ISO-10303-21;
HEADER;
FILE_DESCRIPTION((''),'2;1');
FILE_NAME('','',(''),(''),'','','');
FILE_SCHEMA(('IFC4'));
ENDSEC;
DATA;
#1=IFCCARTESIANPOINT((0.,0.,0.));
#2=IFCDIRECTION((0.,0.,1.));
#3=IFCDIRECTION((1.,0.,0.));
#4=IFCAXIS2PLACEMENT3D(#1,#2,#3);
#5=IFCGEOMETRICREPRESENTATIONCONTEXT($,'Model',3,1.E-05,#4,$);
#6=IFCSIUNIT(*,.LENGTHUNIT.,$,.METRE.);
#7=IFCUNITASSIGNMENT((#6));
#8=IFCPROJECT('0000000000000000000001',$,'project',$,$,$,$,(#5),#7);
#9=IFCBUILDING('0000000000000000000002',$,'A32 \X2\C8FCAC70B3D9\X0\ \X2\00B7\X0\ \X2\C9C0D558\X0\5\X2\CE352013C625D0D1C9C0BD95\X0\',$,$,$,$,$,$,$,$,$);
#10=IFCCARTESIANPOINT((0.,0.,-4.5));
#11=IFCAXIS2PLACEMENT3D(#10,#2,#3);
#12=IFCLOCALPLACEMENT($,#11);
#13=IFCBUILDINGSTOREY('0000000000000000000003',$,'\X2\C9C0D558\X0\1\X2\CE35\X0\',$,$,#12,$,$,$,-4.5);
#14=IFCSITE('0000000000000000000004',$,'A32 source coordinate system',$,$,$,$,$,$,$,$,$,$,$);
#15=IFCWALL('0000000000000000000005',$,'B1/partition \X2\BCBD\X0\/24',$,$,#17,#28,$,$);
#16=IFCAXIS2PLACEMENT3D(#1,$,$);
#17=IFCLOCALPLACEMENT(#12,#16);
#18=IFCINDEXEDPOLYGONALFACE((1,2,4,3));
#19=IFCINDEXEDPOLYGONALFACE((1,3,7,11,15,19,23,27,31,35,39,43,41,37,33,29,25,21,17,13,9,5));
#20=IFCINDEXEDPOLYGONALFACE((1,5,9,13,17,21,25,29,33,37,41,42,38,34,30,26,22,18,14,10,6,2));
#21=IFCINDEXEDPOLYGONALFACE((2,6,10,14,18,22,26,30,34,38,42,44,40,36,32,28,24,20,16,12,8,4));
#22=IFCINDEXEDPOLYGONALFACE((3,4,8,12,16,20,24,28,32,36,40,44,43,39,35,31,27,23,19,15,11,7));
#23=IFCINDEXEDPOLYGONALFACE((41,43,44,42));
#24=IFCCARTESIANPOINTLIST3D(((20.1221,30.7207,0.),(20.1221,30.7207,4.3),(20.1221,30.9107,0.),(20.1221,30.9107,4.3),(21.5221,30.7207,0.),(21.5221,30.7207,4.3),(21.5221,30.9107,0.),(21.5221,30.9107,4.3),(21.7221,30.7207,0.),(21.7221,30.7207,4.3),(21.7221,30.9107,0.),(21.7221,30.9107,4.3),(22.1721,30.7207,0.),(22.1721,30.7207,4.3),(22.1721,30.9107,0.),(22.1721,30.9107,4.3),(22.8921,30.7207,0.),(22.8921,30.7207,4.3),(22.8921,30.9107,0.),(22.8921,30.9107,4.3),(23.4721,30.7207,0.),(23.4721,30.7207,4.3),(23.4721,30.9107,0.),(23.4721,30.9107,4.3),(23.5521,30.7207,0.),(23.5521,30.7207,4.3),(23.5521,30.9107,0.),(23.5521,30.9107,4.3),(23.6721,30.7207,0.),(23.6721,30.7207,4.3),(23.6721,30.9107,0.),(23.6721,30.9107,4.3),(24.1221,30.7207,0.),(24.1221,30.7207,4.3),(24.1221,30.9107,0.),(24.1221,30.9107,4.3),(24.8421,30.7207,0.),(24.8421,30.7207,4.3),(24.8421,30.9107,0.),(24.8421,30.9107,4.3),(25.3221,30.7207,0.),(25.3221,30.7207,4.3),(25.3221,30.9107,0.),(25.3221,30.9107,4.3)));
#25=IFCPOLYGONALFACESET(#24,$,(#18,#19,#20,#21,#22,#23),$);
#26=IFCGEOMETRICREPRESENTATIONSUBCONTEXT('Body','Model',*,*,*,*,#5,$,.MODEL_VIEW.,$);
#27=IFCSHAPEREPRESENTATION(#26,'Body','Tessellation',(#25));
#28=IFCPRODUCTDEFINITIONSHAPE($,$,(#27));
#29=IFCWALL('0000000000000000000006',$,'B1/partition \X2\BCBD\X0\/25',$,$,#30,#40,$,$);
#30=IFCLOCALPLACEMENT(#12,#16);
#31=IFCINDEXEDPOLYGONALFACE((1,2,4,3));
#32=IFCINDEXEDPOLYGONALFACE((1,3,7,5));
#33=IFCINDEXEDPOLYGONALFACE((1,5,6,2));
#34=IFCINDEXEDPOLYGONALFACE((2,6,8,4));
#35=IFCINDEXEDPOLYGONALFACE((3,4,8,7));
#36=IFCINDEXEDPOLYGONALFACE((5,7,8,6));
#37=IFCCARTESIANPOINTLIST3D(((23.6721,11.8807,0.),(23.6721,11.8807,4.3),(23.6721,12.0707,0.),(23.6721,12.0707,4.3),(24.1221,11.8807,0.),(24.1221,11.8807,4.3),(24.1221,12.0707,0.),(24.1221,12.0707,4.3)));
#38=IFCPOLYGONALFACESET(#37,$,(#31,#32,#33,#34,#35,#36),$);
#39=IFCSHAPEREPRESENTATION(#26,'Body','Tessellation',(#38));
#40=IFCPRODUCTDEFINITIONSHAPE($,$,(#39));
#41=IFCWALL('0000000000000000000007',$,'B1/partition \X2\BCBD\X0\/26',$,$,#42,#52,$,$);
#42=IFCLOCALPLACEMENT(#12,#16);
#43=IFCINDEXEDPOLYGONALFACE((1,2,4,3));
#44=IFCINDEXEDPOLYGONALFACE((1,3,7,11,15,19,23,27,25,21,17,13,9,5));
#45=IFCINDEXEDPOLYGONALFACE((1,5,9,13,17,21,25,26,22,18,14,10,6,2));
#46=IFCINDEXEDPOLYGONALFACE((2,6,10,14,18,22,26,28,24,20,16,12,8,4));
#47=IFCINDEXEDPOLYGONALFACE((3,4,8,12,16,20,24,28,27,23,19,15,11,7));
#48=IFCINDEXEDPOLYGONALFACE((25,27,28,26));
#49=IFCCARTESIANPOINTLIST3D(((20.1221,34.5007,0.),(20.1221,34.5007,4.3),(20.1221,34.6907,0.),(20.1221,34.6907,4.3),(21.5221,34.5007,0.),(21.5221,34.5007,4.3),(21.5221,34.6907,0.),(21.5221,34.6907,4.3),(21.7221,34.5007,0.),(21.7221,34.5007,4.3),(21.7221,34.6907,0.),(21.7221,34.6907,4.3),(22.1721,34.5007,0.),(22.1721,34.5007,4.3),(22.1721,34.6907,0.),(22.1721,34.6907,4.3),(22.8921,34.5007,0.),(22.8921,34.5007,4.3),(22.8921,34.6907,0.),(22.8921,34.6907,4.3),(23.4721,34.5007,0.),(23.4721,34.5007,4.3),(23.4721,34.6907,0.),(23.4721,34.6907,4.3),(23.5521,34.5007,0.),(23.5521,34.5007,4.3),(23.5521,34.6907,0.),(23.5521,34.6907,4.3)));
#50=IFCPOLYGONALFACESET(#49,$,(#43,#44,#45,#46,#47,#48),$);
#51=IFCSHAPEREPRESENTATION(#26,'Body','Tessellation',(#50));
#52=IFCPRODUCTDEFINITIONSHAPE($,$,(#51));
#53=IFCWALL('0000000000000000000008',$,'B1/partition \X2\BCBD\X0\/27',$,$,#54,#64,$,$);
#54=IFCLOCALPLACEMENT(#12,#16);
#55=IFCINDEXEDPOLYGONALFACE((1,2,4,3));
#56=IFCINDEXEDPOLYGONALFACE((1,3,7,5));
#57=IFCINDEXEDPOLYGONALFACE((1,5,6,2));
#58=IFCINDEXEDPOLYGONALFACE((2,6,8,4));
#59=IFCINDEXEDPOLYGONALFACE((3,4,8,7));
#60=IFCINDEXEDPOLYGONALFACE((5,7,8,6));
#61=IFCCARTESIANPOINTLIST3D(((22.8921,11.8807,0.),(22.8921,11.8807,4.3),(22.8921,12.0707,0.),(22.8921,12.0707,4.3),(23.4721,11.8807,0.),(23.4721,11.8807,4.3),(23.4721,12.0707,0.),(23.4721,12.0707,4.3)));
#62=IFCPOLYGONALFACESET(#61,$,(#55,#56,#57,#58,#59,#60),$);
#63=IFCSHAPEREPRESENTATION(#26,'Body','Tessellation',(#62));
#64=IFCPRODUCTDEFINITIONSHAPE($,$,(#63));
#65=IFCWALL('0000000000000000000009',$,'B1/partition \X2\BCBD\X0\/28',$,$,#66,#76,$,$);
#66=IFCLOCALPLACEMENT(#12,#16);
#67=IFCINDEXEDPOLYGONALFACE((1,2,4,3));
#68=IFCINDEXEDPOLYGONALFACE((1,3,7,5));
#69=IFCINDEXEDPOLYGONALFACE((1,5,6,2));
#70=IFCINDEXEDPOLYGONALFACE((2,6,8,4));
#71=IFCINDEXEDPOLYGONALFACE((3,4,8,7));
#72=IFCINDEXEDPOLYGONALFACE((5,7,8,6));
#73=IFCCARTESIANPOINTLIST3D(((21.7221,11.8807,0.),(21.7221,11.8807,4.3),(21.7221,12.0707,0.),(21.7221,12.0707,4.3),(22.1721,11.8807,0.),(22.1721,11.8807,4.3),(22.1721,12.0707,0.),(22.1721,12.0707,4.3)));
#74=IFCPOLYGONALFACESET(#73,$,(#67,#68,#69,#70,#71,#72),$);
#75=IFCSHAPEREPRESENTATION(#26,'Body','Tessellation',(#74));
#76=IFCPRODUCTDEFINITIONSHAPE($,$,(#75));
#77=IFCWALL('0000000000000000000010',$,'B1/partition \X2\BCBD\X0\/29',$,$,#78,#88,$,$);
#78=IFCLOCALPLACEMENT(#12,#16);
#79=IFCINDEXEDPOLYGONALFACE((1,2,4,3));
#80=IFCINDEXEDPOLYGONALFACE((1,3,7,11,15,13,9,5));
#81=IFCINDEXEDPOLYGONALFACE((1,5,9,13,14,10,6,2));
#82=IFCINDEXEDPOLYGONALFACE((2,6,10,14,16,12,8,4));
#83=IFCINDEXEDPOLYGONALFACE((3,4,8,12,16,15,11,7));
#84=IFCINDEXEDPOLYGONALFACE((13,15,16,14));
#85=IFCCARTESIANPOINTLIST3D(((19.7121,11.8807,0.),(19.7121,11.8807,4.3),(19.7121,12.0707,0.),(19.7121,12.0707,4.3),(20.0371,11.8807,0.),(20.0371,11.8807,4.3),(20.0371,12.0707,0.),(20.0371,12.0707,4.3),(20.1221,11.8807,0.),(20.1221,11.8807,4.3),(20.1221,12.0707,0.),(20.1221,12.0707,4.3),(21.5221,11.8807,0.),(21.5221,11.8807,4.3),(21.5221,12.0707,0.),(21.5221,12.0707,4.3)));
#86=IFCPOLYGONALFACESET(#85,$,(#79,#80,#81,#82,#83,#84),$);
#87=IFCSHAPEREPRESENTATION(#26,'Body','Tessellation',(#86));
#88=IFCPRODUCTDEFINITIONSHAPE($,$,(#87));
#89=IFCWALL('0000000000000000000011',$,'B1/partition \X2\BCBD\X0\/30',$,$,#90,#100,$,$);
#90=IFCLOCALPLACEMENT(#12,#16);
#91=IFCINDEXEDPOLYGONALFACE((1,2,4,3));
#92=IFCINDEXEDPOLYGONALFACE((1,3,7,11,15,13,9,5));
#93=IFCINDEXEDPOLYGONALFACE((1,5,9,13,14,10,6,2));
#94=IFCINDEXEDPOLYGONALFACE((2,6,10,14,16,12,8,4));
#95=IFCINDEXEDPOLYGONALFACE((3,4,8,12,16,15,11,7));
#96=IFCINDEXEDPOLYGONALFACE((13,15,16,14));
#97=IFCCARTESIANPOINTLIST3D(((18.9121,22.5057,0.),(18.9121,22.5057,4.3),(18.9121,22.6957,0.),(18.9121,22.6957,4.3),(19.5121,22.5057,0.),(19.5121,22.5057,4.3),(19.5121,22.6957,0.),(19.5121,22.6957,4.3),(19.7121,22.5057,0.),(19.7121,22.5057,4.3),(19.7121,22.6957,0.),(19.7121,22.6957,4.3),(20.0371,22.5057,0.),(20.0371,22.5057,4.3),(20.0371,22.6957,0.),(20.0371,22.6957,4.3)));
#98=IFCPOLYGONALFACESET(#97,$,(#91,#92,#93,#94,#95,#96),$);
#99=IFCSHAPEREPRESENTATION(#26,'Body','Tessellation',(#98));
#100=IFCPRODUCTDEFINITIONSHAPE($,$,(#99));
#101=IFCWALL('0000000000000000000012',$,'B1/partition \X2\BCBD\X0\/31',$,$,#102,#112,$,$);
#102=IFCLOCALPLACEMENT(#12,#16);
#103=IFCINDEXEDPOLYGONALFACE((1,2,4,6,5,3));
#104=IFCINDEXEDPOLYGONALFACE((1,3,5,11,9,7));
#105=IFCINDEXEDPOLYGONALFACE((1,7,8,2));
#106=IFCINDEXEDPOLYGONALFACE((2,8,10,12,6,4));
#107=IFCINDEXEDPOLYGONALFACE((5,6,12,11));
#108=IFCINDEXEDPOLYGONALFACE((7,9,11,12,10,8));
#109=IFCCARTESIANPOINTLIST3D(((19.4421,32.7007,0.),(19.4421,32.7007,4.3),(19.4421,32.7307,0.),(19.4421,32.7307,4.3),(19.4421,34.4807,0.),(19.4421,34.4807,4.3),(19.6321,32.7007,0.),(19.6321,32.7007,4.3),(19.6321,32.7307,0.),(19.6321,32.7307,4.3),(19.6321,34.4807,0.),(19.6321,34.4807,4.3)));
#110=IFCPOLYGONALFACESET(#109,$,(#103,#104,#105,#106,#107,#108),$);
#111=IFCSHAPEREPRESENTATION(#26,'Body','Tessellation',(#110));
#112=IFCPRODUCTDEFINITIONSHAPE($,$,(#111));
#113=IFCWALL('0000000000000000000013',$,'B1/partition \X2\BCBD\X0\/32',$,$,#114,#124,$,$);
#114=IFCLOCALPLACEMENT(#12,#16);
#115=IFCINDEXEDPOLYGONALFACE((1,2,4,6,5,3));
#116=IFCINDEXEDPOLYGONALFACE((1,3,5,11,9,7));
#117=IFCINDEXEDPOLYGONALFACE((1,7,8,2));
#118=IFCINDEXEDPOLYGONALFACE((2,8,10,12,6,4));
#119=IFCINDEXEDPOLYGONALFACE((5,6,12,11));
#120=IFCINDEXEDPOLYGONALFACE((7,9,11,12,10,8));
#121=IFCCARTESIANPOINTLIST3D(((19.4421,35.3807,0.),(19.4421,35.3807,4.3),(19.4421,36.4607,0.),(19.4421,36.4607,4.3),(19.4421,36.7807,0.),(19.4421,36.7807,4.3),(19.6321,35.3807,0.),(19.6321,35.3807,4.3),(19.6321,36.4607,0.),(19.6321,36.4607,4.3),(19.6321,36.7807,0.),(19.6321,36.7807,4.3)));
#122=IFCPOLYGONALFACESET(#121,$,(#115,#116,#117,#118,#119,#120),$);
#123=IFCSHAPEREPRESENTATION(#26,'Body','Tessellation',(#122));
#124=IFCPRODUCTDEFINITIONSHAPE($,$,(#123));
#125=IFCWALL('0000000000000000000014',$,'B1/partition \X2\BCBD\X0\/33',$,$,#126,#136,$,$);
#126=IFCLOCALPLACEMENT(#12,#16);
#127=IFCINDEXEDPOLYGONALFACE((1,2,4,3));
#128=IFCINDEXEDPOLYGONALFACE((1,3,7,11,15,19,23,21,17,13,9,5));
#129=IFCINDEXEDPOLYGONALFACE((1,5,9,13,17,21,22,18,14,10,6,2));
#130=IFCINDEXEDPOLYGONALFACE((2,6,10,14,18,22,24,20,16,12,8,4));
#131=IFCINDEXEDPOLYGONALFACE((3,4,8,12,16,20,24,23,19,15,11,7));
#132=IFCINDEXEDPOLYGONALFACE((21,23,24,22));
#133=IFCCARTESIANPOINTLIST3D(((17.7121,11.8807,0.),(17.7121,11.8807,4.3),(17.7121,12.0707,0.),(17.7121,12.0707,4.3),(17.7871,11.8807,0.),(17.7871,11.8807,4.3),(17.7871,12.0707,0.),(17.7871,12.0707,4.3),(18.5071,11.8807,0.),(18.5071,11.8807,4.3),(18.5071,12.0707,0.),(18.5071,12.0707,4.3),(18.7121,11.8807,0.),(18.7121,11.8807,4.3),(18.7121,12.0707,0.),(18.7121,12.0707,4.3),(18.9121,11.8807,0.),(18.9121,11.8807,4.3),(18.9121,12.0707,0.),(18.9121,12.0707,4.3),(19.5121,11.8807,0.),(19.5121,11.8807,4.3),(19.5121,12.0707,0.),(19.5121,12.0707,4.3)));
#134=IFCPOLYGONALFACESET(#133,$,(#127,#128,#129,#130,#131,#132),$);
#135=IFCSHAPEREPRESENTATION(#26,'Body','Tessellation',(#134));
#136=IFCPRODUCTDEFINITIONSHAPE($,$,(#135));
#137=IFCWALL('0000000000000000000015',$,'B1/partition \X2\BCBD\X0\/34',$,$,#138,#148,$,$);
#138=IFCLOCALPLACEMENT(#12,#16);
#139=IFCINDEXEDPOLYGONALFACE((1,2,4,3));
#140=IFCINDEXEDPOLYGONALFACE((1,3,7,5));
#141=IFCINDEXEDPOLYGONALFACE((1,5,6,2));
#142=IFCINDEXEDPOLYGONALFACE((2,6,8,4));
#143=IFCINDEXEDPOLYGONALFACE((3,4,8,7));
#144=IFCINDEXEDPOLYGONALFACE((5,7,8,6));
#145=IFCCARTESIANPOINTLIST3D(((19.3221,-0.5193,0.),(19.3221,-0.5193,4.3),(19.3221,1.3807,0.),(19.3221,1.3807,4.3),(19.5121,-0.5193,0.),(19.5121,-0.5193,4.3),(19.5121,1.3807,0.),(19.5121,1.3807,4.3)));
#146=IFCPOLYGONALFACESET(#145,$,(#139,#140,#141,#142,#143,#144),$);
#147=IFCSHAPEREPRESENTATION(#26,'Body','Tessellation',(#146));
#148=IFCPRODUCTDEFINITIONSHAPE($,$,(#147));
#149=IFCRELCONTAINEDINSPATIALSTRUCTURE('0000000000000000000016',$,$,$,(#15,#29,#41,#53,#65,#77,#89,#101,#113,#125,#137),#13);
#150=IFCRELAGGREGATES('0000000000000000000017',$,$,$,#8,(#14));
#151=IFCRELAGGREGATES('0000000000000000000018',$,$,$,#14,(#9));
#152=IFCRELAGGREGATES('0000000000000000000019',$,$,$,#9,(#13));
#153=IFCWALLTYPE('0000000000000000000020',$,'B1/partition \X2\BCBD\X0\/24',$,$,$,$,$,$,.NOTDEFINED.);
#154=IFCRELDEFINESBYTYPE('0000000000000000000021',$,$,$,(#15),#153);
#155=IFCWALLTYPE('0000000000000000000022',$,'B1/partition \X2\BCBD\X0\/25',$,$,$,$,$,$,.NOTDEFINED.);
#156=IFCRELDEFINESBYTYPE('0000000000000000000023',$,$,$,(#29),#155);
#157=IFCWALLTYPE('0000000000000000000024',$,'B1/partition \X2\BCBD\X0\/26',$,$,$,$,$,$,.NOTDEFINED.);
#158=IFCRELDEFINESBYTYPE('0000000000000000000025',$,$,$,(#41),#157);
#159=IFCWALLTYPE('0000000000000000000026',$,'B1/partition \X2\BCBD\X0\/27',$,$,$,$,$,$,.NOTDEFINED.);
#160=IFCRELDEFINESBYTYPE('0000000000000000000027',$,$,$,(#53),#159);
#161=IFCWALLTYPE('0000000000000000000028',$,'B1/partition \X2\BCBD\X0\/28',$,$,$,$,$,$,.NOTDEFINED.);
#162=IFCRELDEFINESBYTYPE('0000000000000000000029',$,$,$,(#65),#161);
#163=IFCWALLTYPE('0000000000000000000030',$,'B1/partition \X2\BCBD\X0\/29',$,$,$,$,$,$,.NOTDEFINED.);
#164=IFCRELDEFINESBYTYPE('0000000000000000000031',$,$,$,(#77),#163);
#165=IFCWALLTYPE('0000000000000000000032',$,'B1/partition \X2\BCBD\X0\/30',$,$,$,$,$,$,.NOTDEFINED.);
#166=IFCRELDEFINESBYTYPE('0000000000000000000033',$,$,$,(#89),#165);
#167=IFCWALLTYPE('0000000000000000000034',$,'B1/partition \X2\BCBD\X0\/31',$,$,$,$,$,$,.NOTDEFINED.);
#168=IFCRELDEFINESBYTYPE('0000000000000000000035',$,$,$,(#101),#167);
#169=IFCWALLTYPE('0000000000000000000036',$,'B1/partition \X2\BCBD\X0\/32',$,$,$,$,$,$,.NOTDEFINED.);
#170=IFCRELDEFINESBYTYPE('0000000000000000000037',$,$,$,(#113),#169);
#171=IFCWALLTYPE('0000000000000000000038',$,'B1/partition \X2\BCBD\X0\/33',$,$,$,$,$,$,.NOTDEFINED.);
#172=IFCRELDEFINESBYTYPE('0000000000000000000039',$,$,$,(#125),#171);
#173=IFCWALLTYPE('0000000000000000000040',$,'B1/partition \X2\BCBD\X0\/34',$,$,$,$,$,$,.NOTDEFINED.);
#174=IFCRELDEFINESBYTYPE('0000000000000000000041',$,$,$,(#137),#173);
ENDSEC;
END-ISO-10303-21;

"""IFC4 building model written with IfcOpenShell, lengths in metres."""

from ifc_helpers import new_model, si_unit, frame, origin, origin_with_axes, place, context, subcontext, project, spatial, polyline, outline, extrude, source, transform, mapped, type_object, type_shapes, element, save


model = new_model("IFC4")

# Units and contexts
model_context = context("Model", 3, precision=1e-05, world=origin_with_axes())
body_context = subcontext(model_context, "Body", "Model", "MODEL_VIEW")
ifc_project = project(units=[si_unit("LENGTHUNIT", "METRE")], contexts=[model_context])

# Site, building, storey
site = spatial("IfcSite", under=ifc_project, Name="A32 source coordinate system")
building = spatial("IfcBuilding", under=site, Name="A32 주거동 · 지하5층–옥탑지붕")
storey_placement = place(None, frame((0.0, 0.0, -4.5), z_axis=(0.0, 0.0, 1.0), x_axis=(1.0, 0.0, 0.0)))
storey = spatial("IfcBuildingStorey", under=building, at=storey_placement, Name="지하1층", Elevation=-4.5)

# Walls
wall_type_1 = type_object("IfcWallType", Name="B1/partition 벽/24", PredefinedType="NOTDEFINED")
shared_shape_1 = source(origin(), body_context, "Body", "SweptSolid", [
    extrude(outline(polyline([(21.5221, 30.9107), (21.7221, 30.9107), (22.1721, 30.9107), (22.8921, 30.9107), (23.4721, 30.9107), (23.5521, 30.9107), (23.6721, 30.9107), (24.1221, 30.9107), (24.8421, 30.9107), (25.3221, 30.9107), (25.3221, 30.7207), (24.8421, 30.7207), (24.1221, 30.7207), (23.6721, 30.7207), (23.5521, 30.7207), (23.4721, 30.7207), (22.8921, 30.7207), (22.1721, 30.7207), (21.7221, 30.7207), (21.5221, 30.7207), (20.1221, 30.7207), (20.1221, 30.9107), (21.5221, 30.9107)])), origin(), (0.0, 0.0, 1.0), 4.3),
])
type_shapes(wall_type_1, [shared_shape_1])
wall_1_placement = place(storey_placement, origin_with_axes())
element("IfcWall", 1, at=wall_1_placement, inside=storey, type_object=wall_type_1, Name="B1/partition 벽/24", context=body_context, shape_type="MappedRepresentation", body=[
    mapped(shared_shape_1, transform((0.0, 0.0, 0.0), scale=1.0)),
])
wall_type_2 = type_object("IfcWallType", Name="B1/partition 벽/25", PredefinedType="NOTDEFINED")
shared_shape_2 = source(origin(), body_context, "Body", "SweptSolid", [
    extrude(outline(polyline([(24.1221, 12.0707), (24.1221, 11.8807), (23.6721, 11.8807), (23.6721, 12.0707), (24.1221, 12.0707)])), origin(), (0.0, 0.0, 1.0), 4.3),
])
type_shapes(wall_type_2, [shared_shape_2])
wall_2_placement = place(storey_placement, origin_with_axes())
element("IfcWall", 2, at=wall_2_placement, inside=storey, type_object=wall_type_2, Name="B1/partition 벽/25", context=body_context, shape_type="MappedRepresentation", body=[
    mapped(shared_shape_2, transform((0.0, 0.0, 0.0), scale=1.0)),
])
wall_type_3 = type_object("IfcWallType", Name="B1/partition 벽/26", PredefinedType="NOTDEFINED")
shared_shape_3 = source(origin(), body_context, "Body", "SweptSolid", [
    extrude(outline(polyline([(21.7221, 34.5007), (21.5221, 34.5007), (20.1221, 34.5007), (20.1221, 34.6907), (21.5221, 34.6907), (21.7221, 34.6907), (22.1721, 34.6907), (22.8921, 34.6907), (23.4721, 34.6907), (23.5521, 34.6907), (23.5521, 34.5007), (23.4721, 34.5007), (22.8921, 34.5007), (22.1721, 34.5007), (21.7221, 34.5007)])), origin(), (0.0, 0.0, 1.0), 4.3),
])
type_shapes(wall_type_3, [shared_shape_3])
wall_3_placement = place(storey_placement, origin_with_axes())
element("IfcWall", 3, at=wall_3_placement, inside=storey, type_object=wall_type_3, Name="B1/partition 벽/26", context=body_context, shape_type="MappedRepresentation", body=[
    mapped(shared_shape_3, transform((0.0, 0.0, 0.0), scale=1.0)),
])
wall_type_4 = type_object("IfcWallType", Name="B1/partition 벽/27", PredefinedType="NOTDEFINED")
shared_shape_4 = source(origin(), body_context, "Body", "SweptSolid", [
    extrude(outline(polyline([(23.4721, 11.8807), (22.8921, 11.8807), (22.8921, 12.0707), (23.4721, 12.0707), (23.4721, 11.8807)])), origin(), (0.0, 0.0, 1.0), 4.3),
])
type_shapes(wall_type_4, [shared_shape_4])
wall_4_placement = place(storey_placement, origin_with_axes())
element("IfcWall", 4, at=wall_4_placement, inside=storey, type_object=wall_type_4, Name="B1/partition 벽/27", context=body_context, shape_type="MappedRepresentation", body=[
    mapped(shared_shape_4, transform((0.0, 0.0, 0.0), scale=1.0)),
])
wall_type_5 = type_object("IfcWallType", Name="B1/partition 벽/28", PredefinedType="NOTDEFINED")
shared_shape_5 = source(origin(), body_context, "Body", "SweptSolid", [
    extrude(outline(polyline([(22.1721, 11.8807), (21.7221, 11.8807), (21.7221, 12.0707), (22.1721, 12.0707), (22.1721, 11.8807)])), origin(), (0.0, 0.0, 1.0), 4.3),
])
type_shapes(wall_type_5, [shared_shape_5])
wall_5_placement = place(storey_placement, origin_with_axes())
element("IfcWall", 5, at=wall_5_placement, inside=storey, type_object=wall_type_5, Name="B1/partition 벽/28", context=body_context, shape_type="MappedRepresentation", body=[
    mapped(shared_shape_5, transform((0.0, 0.0, 0.0), scale=1.0)),
])
wall_type_6 = type_object("IfcWallType", Name="B1/partition 벽/29", PredefinedType="NOTDEFINED")
shared_shape_6 = source(origin(), body_context, "Body", "SweptSolid", [
    extrude(outline(polyline([(20.0371, 11.8807), (19.7121, 11.8807), (19.7121, 12.0707), (20.0371, 12.0707), (20.1221, 12.0707), (21.5221, 12.0707), (21.5221, 11.8807), (20.1221, 11.8807), (20.0371, 11.8807)])), origin(), (0.0, 0.0, 1.0), 4.3),
])
type_shapes(wall_type_6, [shared_shape_6])
wall_6_placement = place(storey_placement, origin_with_axes())
element("IfcWall", 6, at=wall_6_placement, inside=storey, type_object=wall_type_6, Name="B1/partition 벽/29", context=body_context, shape_type="MappedRepresentation", body=[
    mapped(shared_shape_6, transform((0.0, 0.0, 0.0), scale=1.0)),
])
wall_type_7 = type_object("IfcWallType", Name="B1/partition 벽/30", PredefinedType="NOTDEFINED")
shared_shape_7 = source(origin(), body_context, "Body", "SweptSolid", [
    extrude(outline(polyline([(19.7121, 22.6957), (20.0371, 22.6957), (20.0371, 22.5057), (19.7121, 22.5057), (19.5121, 22.5057), (18.9121, 22.5057), (18.9121, 22.6957), (19.5121, 22.6957), (19.7121, 22.6957)])), origin(), (0.0, 0.0, 1.0), 4.3),
])
type_shapes(wall_type_7, [shared_shape_7])
wall_7_placement = place(storey_placement, origin_with_axes())
element("IfcWall", 7, at=wall_7_placement, inside=storey, type_object=wall_type_7, Name="B1/partition 벽/30", context=body_context, shape_type="MappedRepresentation", body=[
    mapped(shared_shape_7, transform((0.0, 0.0, 0.0), scale=1.0)),
])
wall_type_8 = type_object("IfcWallType", Name="B1/partition 벽/31", PredefinedType="NOTDEFINED")
shared_shape_8 = source(origin(), body_context, "Body", "SweptSolid", [
    extrude(outline(polyline([(19.6321, 32.7007), (19.4421, 32.7007), (19.4421, 32.7307), (19.4421, 34.4807), (19.6321, 34.4807), (19.6321, 32.7307), (19.6321, 32.7007)])), origin(), (0.0, 0.0, 1.0), 4.3),
])
type_shapes(wall_type_8, [shared_shape_8])
wall_8_placement = place(storey_placement, origin_with_axes())
element("IfcWall", 8, at=wall_8_placement, inside=storey, type_object=wall_type_8, Name="B1/partition 벽/31", context=body_context, shape_type="MappedRepresentation", body=[
    mapped(shared_shape_8, transform((0.0, 0.0, 0.0), scale=1.0)),
])
wall_type_9 = type_object("IfcWallType", Name="B1/partition 벽/32", PredefinedType="NOTDEFINED")
shared_shape_9 = source(origin(), body_context, "Body", "SweptSolid", [
    extrude(outline(polyline([(19.6321, 36.7807), (19.6321, 36.4607), (19.6321, 35.3807), (19.4421, 35.3807), (19.4421, 36.4607), (19.4421, 36.7807), (19.6321, 36.7807)])), origin(), (0.0, 0.0, 1.0), 4.3),
])
type_shapes(wall_type_9, [shared_shape_9])
wall_9_placement = place(storey_placement, origin_with_axes())
element("IfcWall", 9, at=wall_9_placement, inside=storey, type_object=wall_type_9, Name="B1/partition 벽/32", context=body_context, shape_type="MappedRepresentation", body=[
    mapped(shared_shape_9, transform((0.0, 0.0, 0.0), scale=1.0)),
])
wall_type_10 = type_object("IfcWallType", Name="B1/partition 벽/33", PredefinedType="NOTDEFINED")
shared_shape_10 = source(origin(), body_context, "Body", "SweptSolid", [
    extrude(outline(polyline([(19.5121, 11.8807), (18.9121, 11.8807), (18.7121, 11.8807), (18.5071, 11.8807), (17.7871, 11.8807), (17.7121, 11.8807), (17.7121, 12.0707), (17.7871, 12.0707), (18.5071, 12.0707), (18.7121, 12.0707), (18.9121, 12.0707), (19.5121, 12.0707), (19.5121, 11.8807)])), origin(), (0.0, 0.0, 1.0), 4.3),
])
type_shapes(wall_type_10, [shared_shape_10])
wall_10_placement = place(storey_placement, origin_with_axes())
element("IfcWall", 10, at=wall_10_placement, inside=storey, type_object=wall_type_10, Name="B1/partition 벽/33", context=body_context, shape_type="MappedRepresentation", body=[
    mapped(shared_shape_10, transform((0.0, 0.0, 0.0), scale=1.0)),
])
wall_type_11 = type_object("IfcWallType", Name="B1/partition 벽/34", PredefinedType="NOTDEFINED")
shared_shape_11 = source(origin(), body_context, "Body", "SweptSolid", [
    extrude(outline(polyline([(19.5121, -0.5193), (19.3221, -0.5193), (19.3221, 1.3807), (19.5121, 1.3807), (19.5121, -0.5193)])), origin(), (0.0, 0.0, 1.0), 4.3),
])
type_shapes(wall_type_11, [shared_shape_11])
wall_11_placement = place(storey_placement, origin_with_axes())
element("IfcWall", 11, at=wall_11_placement, inside=storey, type_object=wall_type_11, Name="B1/partition 벽/34", context=body_context, shape_type="MappedRepresentation", body=[
    mapped(shared_shape_11, transform((0.0, 0.0, 0.0), scale=1.0)),
])

save(model, "model.ifc")
